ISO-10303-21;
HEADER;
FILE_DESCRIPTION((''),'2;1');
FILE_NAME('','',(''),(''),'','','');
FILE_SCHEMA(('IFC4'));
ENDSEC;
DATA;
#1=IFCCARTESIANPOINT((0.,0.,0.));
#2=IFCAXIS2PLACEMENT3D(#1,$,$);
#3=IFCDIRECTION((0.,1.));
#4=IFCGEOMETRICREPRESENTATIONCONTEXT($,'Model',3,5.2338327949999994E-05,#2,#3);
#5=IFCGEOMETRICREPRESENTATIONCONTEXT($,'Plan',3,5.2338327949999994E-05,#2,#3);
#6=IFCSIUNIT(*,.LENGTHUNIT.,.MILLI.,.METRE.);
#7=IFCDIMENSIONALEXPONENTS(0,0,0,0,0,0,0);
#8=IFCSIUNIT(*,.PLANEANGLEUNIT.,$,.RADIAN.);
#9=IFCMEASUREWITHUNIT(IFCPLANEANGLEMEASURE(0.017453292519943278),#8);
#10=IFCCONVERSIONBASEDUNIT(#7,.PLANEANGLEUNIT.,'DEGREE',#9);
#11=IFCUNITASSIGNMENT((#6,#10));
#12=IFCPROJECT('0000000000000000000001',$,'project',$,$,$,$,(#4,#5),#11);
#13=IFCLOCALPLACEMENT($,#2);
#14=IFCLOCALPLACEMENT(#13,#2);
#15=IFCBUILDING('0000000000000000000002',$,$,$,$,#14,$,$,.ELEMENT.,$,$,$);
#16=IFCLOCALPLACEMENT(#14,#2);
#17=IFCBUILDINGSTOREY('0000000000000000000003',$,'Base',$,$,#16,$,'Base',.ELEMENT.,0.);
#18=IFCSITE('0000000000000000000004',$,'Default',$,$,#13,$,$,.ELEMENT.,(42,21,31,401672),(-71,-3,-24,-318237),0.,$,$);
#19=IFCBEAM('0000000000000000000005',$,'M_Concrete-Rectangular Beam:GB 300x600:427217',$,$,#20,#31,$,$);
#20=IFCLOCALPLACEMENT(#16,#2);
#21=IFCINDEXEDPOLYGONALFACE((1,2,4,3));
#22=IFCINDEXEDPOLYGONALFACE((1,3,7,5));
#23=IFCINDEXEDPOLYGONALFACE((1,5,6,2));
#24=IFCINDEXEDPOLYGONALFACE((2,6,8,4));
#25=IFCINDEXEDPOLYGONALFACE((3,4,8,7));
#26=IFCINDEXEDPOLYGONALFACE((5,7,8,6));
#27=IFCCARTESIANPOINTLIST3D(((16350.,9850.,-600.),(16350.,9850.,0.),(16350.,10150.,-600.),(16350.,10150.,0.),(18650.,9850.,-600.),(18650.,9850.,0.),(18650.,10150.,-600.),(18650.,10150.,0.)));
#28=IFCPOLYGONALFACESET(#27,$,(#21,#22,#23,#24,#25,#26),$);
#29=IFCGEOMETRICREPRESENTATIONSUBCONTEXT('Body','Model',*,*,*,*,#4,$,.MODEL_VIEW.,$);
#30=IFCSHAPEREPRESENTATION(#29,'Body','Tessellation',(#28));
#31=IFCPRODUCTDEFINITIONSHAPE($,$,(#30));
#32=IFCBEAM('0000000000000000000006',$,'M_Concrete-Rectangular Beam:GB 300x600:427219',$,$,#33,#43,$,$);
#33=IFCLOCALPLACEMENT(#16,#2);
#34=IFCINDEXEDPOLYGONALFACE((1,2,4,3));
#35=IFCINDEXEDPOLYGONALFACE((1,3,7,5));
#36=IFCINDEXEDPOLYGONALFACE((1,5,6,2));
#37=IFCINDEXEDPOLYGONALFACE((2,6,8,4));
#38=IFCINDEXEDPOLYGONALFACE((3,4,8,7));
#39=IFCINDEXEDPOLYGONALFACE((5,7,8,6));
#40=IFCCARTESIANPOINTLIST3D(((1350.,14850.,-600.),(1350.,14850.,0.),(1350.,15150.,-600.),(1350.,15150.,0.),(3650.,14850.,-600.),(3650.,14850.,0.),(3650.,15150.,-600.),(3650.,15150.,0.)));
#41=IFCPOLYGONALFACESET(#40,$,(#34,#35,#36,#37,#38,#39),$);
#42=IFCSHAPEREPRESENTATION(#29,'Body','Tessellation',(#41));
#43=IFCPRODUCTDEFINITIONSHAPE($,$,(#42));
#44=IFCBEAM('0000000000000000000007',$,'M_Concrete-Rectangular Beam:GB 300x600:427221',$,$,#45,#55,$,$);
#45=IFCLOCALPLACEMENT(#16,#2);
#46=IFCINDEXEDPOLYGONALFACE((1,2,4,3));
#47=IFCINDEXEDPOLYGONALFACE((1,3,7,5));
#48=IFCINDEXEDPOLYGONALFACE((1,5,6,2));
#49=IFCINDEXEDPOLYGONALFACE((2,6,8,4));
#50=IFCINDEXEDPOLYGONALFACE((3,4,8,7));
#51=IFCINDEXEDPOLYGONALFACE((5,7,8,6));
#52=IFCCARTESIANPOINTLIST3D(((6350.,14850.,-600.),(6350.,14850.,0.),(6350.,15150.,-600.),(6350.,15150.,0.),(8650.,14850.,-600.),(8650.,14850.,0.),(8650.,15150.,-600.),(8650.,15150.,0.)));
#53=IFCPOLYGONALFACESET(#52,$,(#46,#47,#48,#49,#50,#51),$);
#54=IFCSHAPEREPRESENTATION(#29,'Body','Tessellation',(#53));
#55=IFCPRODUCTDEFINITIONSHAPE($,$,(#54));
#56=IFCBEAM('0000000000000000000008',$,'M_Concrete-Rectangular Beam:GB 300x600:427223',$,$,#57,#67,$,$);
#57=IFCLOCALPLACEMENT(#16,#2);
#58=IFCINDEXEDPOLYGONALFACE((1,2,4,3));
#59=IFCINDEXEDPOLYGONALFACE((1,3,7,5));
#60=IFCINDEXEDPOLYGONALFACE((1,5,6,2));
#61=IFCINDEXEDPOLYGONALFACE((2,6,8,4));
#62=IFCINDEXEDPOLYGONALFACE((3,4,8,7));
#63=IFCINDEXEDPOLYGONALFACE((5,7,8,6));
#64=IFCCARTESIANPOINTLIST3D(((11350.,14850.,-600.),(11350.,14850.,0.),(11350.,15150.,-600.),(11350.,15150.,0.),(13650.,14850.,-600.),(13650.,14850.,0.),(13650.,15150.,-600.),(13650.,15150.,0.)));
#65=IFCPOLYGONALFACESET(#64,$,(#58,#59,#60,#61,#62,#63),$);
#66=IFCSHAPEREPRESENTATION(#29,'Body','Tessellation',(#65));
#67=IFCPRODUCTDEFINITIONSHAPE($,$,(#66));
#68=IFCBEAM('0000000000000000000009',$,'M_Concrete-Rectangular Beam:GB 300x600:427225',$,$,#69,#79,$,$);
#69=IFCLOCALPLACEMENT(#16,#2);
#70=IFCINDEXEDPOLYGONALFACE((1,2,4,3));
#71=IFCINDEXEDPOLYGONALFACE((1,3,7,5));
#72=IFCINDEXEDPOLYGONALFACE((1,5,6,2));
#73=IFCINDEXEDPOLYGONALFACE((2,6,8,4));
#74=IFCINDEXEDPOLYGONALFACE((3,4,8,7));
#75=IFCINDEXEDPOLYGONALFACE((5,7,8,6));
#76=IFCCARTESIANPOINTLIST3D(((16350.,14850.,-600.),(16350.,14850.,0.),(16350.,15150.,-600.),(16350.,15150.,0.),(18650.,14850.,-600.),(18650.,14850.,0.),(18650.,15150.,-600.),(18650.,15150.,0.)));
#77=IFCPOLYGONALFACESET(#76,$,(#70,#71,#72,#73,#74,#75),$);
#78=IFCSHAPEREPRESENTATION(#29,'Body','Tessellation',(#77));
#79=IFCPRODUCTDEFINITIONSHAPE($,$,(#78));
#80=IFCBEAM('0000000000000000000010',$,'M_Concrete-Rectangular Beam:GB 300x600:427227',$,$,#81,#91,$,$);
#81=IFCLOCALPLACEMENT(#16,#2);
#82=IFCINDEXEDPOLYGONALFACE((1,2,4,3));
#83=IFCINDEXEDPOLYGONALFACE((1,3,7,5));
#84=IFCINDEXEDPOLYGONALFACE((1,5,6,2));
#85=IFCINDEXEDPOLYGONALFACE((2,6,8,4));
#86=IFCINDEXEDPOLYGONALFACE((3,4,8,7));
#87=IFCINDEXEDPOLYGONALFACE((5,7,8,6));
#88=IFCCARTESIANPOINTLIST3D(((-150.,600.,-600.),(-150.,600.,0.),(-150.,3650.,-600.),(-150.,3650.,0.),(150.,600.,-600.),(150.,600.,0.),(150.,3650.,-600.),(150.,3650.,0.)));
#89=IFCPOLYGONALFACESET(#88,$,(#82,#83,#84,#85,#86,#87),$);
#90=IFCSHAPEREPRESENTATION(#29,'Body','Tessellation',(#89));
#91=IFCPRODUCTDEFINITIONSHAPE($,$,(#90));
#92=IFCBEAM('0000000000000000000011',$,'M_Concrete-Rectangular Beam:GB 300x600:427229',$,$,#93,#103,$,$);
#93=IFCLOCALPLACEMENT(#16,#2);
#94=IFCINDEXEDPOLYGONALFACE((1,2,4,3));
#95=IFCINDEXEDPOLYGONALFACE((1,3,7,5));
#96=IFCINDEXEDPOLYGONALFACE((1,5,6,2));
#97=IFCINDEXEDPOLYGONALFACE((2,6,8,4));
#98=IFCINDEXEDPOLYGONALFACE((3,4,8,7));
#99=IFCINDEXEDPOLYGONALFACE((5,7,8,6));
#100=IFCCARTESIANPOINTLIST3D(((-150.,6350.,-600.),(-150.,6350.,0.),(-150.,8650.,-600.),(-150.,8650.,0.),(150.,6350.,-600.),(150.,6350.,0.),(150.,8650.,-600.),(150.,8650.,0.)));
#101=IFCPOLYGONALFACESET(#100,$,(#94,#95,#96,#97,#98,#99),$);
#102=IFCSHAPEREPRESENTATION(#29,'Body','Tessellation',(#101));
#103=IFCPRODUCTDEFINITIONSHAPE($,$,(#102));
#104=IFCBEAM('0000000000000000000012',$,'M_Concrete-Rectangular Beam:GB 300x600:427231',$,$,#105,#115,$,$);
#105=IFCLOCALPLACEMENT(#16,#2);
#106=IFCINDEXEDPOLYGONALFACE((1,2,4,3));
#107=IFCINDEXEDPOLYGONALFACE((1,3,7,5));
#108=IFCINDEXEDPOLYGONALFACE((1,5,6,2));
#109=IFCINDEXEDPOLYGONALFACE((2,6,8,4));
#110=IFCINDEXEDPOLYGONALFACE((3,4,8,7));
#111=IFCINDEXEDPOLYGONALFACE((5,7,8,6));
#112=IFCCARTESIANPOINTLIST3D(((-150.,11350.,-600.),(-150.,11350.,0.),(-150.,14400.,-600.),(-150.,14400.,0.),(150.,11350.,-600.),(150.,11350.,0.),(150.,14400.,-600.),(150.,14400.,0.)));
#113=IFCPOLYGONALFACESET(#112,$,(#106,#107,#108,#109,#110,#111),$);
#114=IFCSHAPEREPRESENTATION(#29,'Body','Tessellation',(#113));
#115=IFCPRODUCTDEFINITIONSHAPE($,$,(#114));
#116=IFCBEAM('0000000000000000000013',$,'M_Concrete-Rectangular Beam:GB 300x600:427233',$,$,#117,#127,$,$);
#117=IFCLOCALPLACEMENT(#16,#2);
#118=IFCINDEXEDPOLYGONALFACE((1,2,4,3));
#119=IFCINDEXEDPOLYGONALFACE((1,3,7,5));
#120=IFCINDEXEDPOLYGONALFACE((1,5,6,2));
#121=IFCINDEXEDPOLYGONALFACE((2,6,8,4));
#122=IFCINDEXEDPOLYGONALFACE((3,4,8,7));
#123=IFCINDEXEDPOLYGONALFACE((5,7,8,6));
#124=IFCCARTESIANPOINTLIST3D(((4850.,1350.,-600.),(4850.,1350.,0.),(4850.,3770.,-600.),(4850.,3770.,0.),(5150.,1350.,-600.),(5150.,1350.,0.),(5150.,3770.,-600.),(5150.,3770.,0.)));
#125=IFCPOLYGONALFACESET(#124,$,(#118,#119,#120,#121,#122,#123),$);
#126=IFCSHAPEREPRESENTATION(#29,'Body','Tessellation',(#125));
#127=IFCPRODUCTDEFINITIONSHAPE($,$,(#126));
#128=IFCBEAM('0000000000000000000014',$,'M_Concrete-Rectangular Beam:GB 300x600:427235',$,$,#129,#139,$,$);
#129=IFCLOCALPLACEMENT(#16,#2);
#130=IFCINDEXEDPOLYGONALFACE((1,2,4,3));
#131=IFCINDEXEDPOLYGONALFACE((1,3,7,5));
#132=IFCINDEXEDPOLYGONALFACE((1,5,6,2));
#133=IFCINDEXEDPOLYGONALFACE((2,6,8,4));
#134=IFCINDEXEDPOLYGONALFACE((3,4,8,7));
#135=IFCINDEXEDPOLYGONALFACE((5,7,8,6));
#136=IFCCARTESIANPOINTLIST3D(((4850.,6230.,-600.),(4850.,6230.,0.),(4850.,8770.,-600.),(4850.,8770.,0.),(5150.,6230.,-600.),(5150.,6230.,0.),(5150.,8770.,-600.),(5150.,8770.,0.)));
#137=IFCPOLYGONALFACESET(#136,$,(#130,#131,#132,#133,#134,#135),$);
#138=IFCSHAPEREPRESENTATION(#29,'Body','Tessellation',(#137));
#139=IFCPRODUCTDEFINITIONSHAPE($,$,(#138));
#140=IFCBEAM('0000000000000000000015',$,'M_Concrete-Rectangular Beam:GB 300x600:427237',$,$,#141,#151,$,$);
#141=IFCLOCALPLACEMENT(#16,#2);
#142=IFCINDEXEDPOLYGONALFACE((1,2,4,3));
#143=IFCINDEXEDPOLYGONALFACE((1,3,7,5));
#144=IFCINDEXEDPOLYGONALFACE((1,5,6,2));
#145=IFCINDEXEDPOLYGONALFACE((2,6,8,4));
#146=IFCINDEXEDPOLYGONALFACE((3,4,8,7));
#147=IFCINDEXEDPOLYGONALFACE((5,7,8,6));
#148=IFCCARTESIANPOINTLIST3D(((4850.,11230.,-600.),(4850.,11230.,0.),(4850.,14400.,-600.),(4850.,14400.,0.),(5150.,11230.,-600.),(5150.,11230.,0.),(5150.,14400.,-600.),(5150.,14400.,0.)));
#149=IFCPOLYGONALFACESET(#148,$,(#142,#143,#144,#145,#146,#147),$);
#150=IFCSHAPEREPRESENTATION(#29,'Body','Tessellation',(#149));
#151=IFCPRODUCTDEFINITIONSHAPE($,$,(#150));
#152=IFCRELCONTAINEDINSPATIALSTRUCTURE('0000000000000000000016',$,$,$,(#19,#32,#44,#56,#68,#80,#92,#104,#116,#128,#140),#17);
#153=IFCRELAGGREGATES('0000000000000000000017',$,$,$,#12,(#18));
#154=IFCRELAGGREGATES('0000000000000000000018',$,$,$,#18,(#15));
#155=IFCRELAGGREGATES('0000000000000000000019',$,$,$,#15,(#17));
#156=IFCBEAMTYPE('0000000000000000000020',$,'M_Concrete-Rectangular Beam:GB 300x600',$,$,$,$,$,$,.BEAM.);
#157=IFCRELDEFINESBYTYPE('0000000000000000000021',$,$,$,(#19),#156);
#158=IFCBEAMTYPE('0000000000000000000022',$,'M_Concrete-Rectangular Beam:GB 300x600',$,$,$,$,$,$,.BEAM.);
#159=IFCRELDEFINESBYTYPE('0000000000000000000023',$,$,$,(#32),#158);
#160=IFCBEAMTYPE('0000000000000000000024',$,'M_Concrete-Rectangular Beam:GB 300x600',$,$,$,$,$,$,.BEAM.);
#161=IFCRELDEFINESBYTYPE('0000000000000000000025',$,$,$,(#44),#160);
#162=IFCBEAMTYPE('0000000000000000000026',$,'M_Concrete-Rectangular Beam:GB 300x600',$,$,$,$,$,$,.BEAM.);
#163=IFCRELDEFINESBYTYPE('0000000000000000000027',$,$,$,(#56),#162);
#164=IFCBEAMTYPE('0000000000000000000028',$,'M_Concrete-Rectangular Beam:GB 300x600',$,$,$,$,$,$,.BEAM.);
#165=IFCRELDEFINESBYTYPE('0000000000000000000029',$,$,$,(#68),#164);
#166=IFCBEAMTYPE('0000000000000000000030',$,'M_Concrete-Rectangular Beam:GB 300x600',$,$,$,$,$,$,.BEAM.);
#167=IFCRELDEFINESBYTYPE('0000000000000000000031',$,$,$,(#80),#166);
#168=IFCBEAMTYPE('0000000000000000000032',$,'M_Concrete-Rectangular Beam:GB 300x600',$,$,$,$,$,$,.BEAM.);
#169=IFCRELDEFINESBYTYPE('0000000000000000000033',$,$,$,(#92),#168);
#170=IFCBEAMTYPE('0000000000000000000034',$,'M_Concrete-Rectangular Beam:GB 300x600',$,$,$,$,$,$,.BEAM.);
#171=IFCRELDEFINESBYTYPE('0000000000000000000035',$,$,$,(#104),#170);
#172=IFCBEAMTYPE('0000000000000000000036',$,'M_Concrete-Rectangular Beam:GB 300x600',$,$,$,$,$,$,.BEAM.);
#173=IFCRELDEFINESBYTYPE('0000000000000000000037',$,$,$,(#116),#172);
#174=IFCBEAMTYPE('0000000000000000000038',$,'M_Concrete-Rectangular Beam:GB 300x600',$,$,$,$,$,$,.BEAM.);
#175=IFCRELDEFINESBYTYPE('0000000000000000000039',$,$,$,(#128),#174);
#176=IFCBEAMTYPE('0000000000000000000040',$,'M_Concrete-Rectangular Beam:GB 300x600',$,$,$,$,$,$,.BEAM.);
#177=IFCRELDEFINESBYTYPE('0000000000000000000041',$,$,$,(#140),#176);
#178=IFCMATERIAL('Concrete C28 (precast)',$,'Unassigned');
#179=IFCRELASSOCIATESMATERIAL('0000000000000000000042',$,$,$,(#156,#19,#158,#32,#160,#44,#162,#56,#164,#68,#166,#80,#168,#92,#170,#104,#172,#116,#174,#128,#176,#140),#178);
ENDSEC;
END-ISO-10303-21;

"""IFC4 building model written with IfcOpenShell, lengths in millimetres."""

from ifc_helpers import new_model, entity, si_unit, converted_unit, direction, frame, origin, place, context, subcontext, project, spatial, indexed_curve, outline, extrude, source, transform, mapped, material, type_object, type_shapes, element, save


model = new_model("IFC4")

# Units and contexts
model_context = context("Model", 3, precision=5.2338327949999994e-05, world=origin(), true_north=direction((0.0, 1.0)))
plan_context = context("Plan", 3, precision=5.2338327949999994e-05, world=origin(), true_north=direction((0.0, 1.0)))
body_context = subcontext(model_context, "Body", "Model", "MODEL_VIEW")
ifc_project = project(units=[si_unit("LENGTHUNIT", "METRE", prefix="MILLI"), converted_unit("PLANEANGLEUNIT", "DEGREE", entity("IfcPlaneAngleMeasure", 0.017453292519943278), si_unit("PLANEANGLEUNIT", "RADIAN"), dimensions=[0, 0, 0, 0, 0, 0, 0])], contexts=[model_context, plan_context])

# Site, building, storey
site_placement = place(None, origin())
site = spatial("IfcSite", under=ifc_project, at=site_placement, Name="Default", CompositionType="ELEMENT", RefLatitude=(42, 21, 31, 401672), RefLongitude=(-71, -3, -24, -318237), RefElevation=0.0)
building_placement = place(site_placement, origin())
building = spatial("IfcBuilding", under=site, at=building_placement, CompositionType="ELEMENT")
storey_placement = place(building_placement, origin())
storey = spatial("IfcBuildingStorey", under=building, at=storey_placement, Name="Base", LongName="Base", CompositionType="ELEMENT", Elevation=0.0)

# Beams
ifc_material = material(Name="Concrete C28 (precast)", Category="Unassigned")
beam_type_1 = type_object("IfcBeamType", Name="M_Concrete-Rectangular Beam:GB 300x600", PredefinedType="BEAM", material=ifc_material)
shared_shape_1 = source(origin(), body_context, "Body", "SweptSolid", [
    extrude(outline(indexed_curve([(-300.0, -150.0), (300.0, -150.0), (300.0, 150.0), (-300.0, 150.0), (-300.0, -150.0)], self_intersect=False)), frame((16350.0, 10000.0, -300.0), z_axis=(1.0, 0.0, 0.0), x_axis=(0.0, 0.0, -1.0)), (0.0, 0.0, 1.0), 2300.0),
])
type_shapes(beam_type_1, [shared_shape_1])
beam_1_placement = place(storey_placement, origin())
element("IfcBeam", 1, at=beam_1_placement, inside=storey, type_object=beam_type_1, material=ifc_material, Name="M_Concrete-Rectangular Beam:GB 300x600:427217", context=body_context, shape_type="MappedRepresentation", body=[
    mapped(shared_shape_1, transform((0.0, 0.0, 0.0), scale=1.0)),
])
beam_type_2 = type_object("IfcBeamType", Name="M_Concrete-Rectangular Beam:GB 300x600", PredefinedType="BEAM", material=ifc_material)
shared_shape_2 = source(origin(), body_context, "Body", "SweptSolid", [
    extrude(outline(indexed_curve([(-300.0, -150.0), (300.0, -150.0), (300.0, 150.0), (-300.0, 150.0), (-300.0, -150.0)], self_intersect=False)), frame((1350.0, 15000.0, -300.0), z_axis=(1.0, 0.0, 0.0), x_axis=(0.0, 0.0, -1.0)), (0.0, 0.0, 1.0), 2300.0),
])
type_shapes(beam_type_2, [shared_shape_2])
beam_2_placement = place(storey_placement, origin())
element("IfcBeam", 2, at=beam_2_placement, inside=storey, type_object=beam_type_2, material=ifc_material, Name="M_Concrete-Rectangular Beam:GB 300x600:427219", context=body_context, shape_type="MappedRepresentation", body=[
    mapped(shared_shape_2, transform((0.0, 0.0, 0.0), scale=1.0)),
])
beam_type_3 = type_object("IfcBeamType", Name="M_Concrete-Rectangular Beam:GB 300x600", PredefinedType="BEAM", material=ifc_material)
shared_shape_3 = source(origin(), body_context, "Body", "SweptSolid", [
    extrude(outline(indexed_curve([(-300.0, -150.0), (300.0, -150.0), (300.0, 150.0), (-300.0, 150.0), (-300.0, -150.0)], self_intersect=False)), frame((6350.0, 15000.0, -300.0), z_axis=(1.0, 0.0, 0.0), x_axis=(0.0, 0.0, -1.0)), (0.0, 0.0, 1.0), 2300.0),
])
type_shapes(beam_type_3, [shared_shape_3])
beam_3_placement = place(storey_placement, origin())
element("IfcBeam", 3, at=beam_3_placement, inside=storey, type_object=beam_type_3, material=ifc_material, Name="M_Concrete-Rectangular Beam:GB 300x600:427221", context=body_context, shape_type="MappedRepresentation", body=[
    mapped(shared_shape_3, transform((0.0, 0.0, 0.0), scale=1.0)),
])
beam_type_4 = type_object("IfcBeamType", Name="M_Concrete-Rectangular Beam:GB 300x600", PredefinedType="BEAM", material=ifc_material)
shared_shape_4 = source(origin(), body_context, "Body", "SweptSolid", [
    extrude(outline(indexed_curve([(-300.0, -150.0), (300.0, -150.0), (300.0, 150.0), (-300.0, 150.0), (-300.0, -150.0)], self_intersect=False)), frame((11350.0, 15000.0, -300.0), z_axis=(1.0, 0.0, 0.0), x_axis=(0.0, 0.0, -1.0)), (0.0, 0.0, 1.0), 2300.0),
])
type_shapes(beam_type_4, [shared_shape_4])
beam_4_placement = place(storey_placement, origin())
element("IfcBeam", 4, at=beam_4_placement, inside=storey, type_object=beam_type_4, material=ifc_material, Name="M_Concrete-Rectangular Beam:GB 300x600:427223", context=body_context, shape_type="MappedRepresentation", body=[
    mapped(shared_shape_4, transform((0.0, 0.0, 0.0), scale=1.0)),
])
beam_type_5 = type_object("IfcBeamType", Name="M_Concrete-Rectangular Beam:GB 300x600", PredefinedType="BEAM", material=ifc_material)
shared_shape_5 = source(origin(), body_context, "Body", "SweptSolid", [
    extrude(outline(indexed_curve([(-300.0, -150.0), (300.0, -150.0), (300.0, 150.0), (-300.0, 150.0), (-300.0, -150.0)], self_intersect=False)), frame((16350.0, 15000.0, -300.0), z_axis=(1.0, 0.0, 0.0), x_axis=(0.0, 0.0, -1.0)), (0.0, 0.0, 1.0), 2300.0),
])
type_shapes(beam_type_5, [shared_shape_5])
beam_5_placement = place(storey_placement, origin())
element("IfcBeam", 5, at=beam_5_placement, inside=storey, type_object=beam_type_5, material=ifc_material, Name="M_Concrete-Rectangular Beam:GB 300x600:427225", context=body_context, shape_type="MappedRepresentation", body=[
    mapped(shared_shape_5, transform((0.0, 0.0, 0.0), scale=1.0)),
])
beam_type_6 = type_object("IfcBeamType", Name="M_Concrete-Rectangular Beam:GB 300x600", PredefinedType="BEAM", material=ifc_material)
shared_shape_6 = source(origin(), body_context, "Body", "SweptSolid", [
    extrude(outline(indexed_curve([(-150.0, -300.0), (150.0, -300.0), (150.0, 300.0), (-150.0, 300.0), (-150.0, -300.0)], self_intersect=False)), frame((0.0, 600.0, -300.0), z_axis=(0.0, 1.0, 0.0), x_axis=(-1.0, 0.0, 0.0)), (0.0, 0.0, 1.0), 3050.0),
])
type_shapes(beam_type_6, [shared_shape_6])
beam_6_placement = place(storey_placement, origin())
element("IfcBeam", 6, at=beam_6_placement, inside=storey, type_object=beam_type_6, material=ifc_material, Name="M_Concrete-Rectangular Beam:GB 300x600:427227", context=body_context, shape_type="MappedRepresentation", body=[
    mapped(shared_shape_6, transform((0.0, 0.0, 0.0), scale=1.0)),
])
beam_type_7 = type_object("IfcBeamType", Name="M_Concrete-Rectangular Beam:GB 300x600", PredefinedType="BEAM", material=ifc_material)
shared_shape_7 = source(origin(), body_context, "Body", "SweptSolid", [
    extrude(outline(indexed_curve([(-150.0, -300.0), (150.0, -300.0), (150.0, 300.0), (-150.0, 300.0), (-150.0, -300.0)], self_intersect=False)), frame((0.0, 6350.0, -300.0), z_axis=(0.0, 1.0, 0.0), x_axis=(-1.0, 0.0, 0.0)), (0.0, 0.0, 1.0), 2300.0),
])
type_shapes(beam_type_7, [shared_shape_7])
beam_7_placement = place(storey_placement, origin())
element("IfcBeam", 7, at=beam_7_placement, inside=storey, type_object=beam_type_7, material=ifc_material, Name="M_Concrete-Rectangular Beam:GB 300x600:427229", context=body_context, shape_type="MappedRepresentation", body=[
    mapped(shared_shape_7, transform((0.0, 0.0, 0.0), scale=1.0)),
])
beam_type_8 = type_object("IfcBeamType", Name="M_Concrete-Rectangular Beam:GB 300x600", PredefinedType="BEAM", material=ifc_material)
shared_shape_8 = source(origin(), body_context, "Body", "SweptSolid", [
    extrude(outline(indexed_curve([(-150.0, -300.0), (150.0, -300.0), (150.0, 300.0), (-150.0, 300.0), (-150.0, -300.0)], self_intersect=False)), frame((0.0, 11350.0, -300.0), z_axis=(0.0, 1.0, 0.0), x_axis=(-1.0, 0.0, 0.0)), (0.0, 0.0, 1.0), 3050.0),
])
type_shapes(beam_type_8, [shared_shape_8])
beam_8_placement = place(storey_placement, origin())
element("IfcBeam", 8, at=beam_8_placement, inside=storey, type_object=beam_type_8, material=ifc_material, Name="M_Concrete-Rectangular Beam:GB 300x600:427231", context=body_context, shape_type="MappedRepresentation", body=[
    mapped(shared_shape_8, transform((0.0, 0.0, 0.0), scale=1.0)),
])
beam_type_9 = type_object("IfcBeamType", Name="M_Concrete-Rectangular Beam:GB 300x600", PredefinedType="BEAM", material=ifc_material)
shared_shape_9 = source(origin(), body_context, "Body", "SweptSolid", [
    extrude(outline(indexed_curve([(-150.0, -300.0), (150.0, -300.0), (150.0, 300.0), (-150.0, 300.0), (-150.0, -300.0)], self_intersect=False)), frame((5000.0, 1350.0, -300.0), z_axis=(0.0, 1.0, 0.0), x_axis=(-1.0, 0.0, 0.0)), (0.0, 0.0, 1.0), 2420.0),
])
type_shapes(beam_type_9, [shared_shape_9])
beam_9_placement = place(storey_placement, origin())
element("IfcBeam", 9, at=beam_9_placement, inside=storey, type_object=beam_type_9, material=ifc_material, Name="M_Concrete-Rectangular Beam:GB 300x600:427233", context=body_context, shape_type="MappedRepresentation", body=[
    mapped(shared_shape_9, transform((0.0, 0.0, 0.0), scale=1.0)),
])
beam_type_10 = type_object("IfcBeamType", Name="M_Concrete-Rectangular Beam:GB 300x600", PredefinedType="BEAM", material=ifc_material)
shared_shape_10 = source(origin(), body_context, "Body", "SweptSolid", [
    extrude(outline(indexed_curve([(-150.0, -300.0), (150.0, -300.0), (150.0, 300.0), (-150.0, 300.0), (-150.0, -300.0)], self_intersect=False)), frame((5000.0, 6230.0, -300.0), z_axis=(0.0, 1.0, 0.0), x_axis=(-1.0, 0.0, 0.0)), (0.0, 0.0, 1.0), 2540.0),
])
type_shapes(beam_type_10, [shared_shape_10])
beam_10_placement = place(storey_placement, origin())
element("IfcBeam", 10, at=beam_10_placement, inside=storey, type_object=beam_type_10, material=ifc_material, Name="M_Concrete-Rectangular Beam:GB 300x600:427235", context=body_context, shape_type="MappedRepresentation", body=[
    mapped(shared_shape_10, transform((0.0, 0.0, 0.0), scale=1.0)),
])
beam_type_11 = type_object("IfcBeamType", Name="M_Concrete-Rectangular Beam:GB 300x600", PredefinedType="BEAM", material=ifc_material)
shared_shape_11 = source(origin(), body_context, "Body", "SweptSolid", [
    extrude(outline(indexed_curve([(-150.0, -300.0), (150.0, -300.0), (150.0, 300.0), (-150.0, 300.0), (-150.0, -300.0)], self_intersect=False)), frame((5000.0, 11230.0, -300.0), z_axis=(0.0, 1.0, 0.0), x_axis=(-1.0, 0.0, 0.0)), (0.0, 0.0, 1.0), 3170.0),
])
type_shapes(beam_type_11, [shared_shape_11])
beam_11_placement = place(storey_placement, origin())
element("IfcBeam", 11, at=beam_11_placement, inside=storey, type_object=beam_type_11, material=ifc_material, Name="M_Concrete-Rectangular Beam:GB 300x600:427237", context=body_context, shape_type="MappedRepresentation", body=[
    mapped(shared_shape_11, transform((0.0, 0.0, 0.0), scale=1.0)),
])

save(model, "model.ifc")
